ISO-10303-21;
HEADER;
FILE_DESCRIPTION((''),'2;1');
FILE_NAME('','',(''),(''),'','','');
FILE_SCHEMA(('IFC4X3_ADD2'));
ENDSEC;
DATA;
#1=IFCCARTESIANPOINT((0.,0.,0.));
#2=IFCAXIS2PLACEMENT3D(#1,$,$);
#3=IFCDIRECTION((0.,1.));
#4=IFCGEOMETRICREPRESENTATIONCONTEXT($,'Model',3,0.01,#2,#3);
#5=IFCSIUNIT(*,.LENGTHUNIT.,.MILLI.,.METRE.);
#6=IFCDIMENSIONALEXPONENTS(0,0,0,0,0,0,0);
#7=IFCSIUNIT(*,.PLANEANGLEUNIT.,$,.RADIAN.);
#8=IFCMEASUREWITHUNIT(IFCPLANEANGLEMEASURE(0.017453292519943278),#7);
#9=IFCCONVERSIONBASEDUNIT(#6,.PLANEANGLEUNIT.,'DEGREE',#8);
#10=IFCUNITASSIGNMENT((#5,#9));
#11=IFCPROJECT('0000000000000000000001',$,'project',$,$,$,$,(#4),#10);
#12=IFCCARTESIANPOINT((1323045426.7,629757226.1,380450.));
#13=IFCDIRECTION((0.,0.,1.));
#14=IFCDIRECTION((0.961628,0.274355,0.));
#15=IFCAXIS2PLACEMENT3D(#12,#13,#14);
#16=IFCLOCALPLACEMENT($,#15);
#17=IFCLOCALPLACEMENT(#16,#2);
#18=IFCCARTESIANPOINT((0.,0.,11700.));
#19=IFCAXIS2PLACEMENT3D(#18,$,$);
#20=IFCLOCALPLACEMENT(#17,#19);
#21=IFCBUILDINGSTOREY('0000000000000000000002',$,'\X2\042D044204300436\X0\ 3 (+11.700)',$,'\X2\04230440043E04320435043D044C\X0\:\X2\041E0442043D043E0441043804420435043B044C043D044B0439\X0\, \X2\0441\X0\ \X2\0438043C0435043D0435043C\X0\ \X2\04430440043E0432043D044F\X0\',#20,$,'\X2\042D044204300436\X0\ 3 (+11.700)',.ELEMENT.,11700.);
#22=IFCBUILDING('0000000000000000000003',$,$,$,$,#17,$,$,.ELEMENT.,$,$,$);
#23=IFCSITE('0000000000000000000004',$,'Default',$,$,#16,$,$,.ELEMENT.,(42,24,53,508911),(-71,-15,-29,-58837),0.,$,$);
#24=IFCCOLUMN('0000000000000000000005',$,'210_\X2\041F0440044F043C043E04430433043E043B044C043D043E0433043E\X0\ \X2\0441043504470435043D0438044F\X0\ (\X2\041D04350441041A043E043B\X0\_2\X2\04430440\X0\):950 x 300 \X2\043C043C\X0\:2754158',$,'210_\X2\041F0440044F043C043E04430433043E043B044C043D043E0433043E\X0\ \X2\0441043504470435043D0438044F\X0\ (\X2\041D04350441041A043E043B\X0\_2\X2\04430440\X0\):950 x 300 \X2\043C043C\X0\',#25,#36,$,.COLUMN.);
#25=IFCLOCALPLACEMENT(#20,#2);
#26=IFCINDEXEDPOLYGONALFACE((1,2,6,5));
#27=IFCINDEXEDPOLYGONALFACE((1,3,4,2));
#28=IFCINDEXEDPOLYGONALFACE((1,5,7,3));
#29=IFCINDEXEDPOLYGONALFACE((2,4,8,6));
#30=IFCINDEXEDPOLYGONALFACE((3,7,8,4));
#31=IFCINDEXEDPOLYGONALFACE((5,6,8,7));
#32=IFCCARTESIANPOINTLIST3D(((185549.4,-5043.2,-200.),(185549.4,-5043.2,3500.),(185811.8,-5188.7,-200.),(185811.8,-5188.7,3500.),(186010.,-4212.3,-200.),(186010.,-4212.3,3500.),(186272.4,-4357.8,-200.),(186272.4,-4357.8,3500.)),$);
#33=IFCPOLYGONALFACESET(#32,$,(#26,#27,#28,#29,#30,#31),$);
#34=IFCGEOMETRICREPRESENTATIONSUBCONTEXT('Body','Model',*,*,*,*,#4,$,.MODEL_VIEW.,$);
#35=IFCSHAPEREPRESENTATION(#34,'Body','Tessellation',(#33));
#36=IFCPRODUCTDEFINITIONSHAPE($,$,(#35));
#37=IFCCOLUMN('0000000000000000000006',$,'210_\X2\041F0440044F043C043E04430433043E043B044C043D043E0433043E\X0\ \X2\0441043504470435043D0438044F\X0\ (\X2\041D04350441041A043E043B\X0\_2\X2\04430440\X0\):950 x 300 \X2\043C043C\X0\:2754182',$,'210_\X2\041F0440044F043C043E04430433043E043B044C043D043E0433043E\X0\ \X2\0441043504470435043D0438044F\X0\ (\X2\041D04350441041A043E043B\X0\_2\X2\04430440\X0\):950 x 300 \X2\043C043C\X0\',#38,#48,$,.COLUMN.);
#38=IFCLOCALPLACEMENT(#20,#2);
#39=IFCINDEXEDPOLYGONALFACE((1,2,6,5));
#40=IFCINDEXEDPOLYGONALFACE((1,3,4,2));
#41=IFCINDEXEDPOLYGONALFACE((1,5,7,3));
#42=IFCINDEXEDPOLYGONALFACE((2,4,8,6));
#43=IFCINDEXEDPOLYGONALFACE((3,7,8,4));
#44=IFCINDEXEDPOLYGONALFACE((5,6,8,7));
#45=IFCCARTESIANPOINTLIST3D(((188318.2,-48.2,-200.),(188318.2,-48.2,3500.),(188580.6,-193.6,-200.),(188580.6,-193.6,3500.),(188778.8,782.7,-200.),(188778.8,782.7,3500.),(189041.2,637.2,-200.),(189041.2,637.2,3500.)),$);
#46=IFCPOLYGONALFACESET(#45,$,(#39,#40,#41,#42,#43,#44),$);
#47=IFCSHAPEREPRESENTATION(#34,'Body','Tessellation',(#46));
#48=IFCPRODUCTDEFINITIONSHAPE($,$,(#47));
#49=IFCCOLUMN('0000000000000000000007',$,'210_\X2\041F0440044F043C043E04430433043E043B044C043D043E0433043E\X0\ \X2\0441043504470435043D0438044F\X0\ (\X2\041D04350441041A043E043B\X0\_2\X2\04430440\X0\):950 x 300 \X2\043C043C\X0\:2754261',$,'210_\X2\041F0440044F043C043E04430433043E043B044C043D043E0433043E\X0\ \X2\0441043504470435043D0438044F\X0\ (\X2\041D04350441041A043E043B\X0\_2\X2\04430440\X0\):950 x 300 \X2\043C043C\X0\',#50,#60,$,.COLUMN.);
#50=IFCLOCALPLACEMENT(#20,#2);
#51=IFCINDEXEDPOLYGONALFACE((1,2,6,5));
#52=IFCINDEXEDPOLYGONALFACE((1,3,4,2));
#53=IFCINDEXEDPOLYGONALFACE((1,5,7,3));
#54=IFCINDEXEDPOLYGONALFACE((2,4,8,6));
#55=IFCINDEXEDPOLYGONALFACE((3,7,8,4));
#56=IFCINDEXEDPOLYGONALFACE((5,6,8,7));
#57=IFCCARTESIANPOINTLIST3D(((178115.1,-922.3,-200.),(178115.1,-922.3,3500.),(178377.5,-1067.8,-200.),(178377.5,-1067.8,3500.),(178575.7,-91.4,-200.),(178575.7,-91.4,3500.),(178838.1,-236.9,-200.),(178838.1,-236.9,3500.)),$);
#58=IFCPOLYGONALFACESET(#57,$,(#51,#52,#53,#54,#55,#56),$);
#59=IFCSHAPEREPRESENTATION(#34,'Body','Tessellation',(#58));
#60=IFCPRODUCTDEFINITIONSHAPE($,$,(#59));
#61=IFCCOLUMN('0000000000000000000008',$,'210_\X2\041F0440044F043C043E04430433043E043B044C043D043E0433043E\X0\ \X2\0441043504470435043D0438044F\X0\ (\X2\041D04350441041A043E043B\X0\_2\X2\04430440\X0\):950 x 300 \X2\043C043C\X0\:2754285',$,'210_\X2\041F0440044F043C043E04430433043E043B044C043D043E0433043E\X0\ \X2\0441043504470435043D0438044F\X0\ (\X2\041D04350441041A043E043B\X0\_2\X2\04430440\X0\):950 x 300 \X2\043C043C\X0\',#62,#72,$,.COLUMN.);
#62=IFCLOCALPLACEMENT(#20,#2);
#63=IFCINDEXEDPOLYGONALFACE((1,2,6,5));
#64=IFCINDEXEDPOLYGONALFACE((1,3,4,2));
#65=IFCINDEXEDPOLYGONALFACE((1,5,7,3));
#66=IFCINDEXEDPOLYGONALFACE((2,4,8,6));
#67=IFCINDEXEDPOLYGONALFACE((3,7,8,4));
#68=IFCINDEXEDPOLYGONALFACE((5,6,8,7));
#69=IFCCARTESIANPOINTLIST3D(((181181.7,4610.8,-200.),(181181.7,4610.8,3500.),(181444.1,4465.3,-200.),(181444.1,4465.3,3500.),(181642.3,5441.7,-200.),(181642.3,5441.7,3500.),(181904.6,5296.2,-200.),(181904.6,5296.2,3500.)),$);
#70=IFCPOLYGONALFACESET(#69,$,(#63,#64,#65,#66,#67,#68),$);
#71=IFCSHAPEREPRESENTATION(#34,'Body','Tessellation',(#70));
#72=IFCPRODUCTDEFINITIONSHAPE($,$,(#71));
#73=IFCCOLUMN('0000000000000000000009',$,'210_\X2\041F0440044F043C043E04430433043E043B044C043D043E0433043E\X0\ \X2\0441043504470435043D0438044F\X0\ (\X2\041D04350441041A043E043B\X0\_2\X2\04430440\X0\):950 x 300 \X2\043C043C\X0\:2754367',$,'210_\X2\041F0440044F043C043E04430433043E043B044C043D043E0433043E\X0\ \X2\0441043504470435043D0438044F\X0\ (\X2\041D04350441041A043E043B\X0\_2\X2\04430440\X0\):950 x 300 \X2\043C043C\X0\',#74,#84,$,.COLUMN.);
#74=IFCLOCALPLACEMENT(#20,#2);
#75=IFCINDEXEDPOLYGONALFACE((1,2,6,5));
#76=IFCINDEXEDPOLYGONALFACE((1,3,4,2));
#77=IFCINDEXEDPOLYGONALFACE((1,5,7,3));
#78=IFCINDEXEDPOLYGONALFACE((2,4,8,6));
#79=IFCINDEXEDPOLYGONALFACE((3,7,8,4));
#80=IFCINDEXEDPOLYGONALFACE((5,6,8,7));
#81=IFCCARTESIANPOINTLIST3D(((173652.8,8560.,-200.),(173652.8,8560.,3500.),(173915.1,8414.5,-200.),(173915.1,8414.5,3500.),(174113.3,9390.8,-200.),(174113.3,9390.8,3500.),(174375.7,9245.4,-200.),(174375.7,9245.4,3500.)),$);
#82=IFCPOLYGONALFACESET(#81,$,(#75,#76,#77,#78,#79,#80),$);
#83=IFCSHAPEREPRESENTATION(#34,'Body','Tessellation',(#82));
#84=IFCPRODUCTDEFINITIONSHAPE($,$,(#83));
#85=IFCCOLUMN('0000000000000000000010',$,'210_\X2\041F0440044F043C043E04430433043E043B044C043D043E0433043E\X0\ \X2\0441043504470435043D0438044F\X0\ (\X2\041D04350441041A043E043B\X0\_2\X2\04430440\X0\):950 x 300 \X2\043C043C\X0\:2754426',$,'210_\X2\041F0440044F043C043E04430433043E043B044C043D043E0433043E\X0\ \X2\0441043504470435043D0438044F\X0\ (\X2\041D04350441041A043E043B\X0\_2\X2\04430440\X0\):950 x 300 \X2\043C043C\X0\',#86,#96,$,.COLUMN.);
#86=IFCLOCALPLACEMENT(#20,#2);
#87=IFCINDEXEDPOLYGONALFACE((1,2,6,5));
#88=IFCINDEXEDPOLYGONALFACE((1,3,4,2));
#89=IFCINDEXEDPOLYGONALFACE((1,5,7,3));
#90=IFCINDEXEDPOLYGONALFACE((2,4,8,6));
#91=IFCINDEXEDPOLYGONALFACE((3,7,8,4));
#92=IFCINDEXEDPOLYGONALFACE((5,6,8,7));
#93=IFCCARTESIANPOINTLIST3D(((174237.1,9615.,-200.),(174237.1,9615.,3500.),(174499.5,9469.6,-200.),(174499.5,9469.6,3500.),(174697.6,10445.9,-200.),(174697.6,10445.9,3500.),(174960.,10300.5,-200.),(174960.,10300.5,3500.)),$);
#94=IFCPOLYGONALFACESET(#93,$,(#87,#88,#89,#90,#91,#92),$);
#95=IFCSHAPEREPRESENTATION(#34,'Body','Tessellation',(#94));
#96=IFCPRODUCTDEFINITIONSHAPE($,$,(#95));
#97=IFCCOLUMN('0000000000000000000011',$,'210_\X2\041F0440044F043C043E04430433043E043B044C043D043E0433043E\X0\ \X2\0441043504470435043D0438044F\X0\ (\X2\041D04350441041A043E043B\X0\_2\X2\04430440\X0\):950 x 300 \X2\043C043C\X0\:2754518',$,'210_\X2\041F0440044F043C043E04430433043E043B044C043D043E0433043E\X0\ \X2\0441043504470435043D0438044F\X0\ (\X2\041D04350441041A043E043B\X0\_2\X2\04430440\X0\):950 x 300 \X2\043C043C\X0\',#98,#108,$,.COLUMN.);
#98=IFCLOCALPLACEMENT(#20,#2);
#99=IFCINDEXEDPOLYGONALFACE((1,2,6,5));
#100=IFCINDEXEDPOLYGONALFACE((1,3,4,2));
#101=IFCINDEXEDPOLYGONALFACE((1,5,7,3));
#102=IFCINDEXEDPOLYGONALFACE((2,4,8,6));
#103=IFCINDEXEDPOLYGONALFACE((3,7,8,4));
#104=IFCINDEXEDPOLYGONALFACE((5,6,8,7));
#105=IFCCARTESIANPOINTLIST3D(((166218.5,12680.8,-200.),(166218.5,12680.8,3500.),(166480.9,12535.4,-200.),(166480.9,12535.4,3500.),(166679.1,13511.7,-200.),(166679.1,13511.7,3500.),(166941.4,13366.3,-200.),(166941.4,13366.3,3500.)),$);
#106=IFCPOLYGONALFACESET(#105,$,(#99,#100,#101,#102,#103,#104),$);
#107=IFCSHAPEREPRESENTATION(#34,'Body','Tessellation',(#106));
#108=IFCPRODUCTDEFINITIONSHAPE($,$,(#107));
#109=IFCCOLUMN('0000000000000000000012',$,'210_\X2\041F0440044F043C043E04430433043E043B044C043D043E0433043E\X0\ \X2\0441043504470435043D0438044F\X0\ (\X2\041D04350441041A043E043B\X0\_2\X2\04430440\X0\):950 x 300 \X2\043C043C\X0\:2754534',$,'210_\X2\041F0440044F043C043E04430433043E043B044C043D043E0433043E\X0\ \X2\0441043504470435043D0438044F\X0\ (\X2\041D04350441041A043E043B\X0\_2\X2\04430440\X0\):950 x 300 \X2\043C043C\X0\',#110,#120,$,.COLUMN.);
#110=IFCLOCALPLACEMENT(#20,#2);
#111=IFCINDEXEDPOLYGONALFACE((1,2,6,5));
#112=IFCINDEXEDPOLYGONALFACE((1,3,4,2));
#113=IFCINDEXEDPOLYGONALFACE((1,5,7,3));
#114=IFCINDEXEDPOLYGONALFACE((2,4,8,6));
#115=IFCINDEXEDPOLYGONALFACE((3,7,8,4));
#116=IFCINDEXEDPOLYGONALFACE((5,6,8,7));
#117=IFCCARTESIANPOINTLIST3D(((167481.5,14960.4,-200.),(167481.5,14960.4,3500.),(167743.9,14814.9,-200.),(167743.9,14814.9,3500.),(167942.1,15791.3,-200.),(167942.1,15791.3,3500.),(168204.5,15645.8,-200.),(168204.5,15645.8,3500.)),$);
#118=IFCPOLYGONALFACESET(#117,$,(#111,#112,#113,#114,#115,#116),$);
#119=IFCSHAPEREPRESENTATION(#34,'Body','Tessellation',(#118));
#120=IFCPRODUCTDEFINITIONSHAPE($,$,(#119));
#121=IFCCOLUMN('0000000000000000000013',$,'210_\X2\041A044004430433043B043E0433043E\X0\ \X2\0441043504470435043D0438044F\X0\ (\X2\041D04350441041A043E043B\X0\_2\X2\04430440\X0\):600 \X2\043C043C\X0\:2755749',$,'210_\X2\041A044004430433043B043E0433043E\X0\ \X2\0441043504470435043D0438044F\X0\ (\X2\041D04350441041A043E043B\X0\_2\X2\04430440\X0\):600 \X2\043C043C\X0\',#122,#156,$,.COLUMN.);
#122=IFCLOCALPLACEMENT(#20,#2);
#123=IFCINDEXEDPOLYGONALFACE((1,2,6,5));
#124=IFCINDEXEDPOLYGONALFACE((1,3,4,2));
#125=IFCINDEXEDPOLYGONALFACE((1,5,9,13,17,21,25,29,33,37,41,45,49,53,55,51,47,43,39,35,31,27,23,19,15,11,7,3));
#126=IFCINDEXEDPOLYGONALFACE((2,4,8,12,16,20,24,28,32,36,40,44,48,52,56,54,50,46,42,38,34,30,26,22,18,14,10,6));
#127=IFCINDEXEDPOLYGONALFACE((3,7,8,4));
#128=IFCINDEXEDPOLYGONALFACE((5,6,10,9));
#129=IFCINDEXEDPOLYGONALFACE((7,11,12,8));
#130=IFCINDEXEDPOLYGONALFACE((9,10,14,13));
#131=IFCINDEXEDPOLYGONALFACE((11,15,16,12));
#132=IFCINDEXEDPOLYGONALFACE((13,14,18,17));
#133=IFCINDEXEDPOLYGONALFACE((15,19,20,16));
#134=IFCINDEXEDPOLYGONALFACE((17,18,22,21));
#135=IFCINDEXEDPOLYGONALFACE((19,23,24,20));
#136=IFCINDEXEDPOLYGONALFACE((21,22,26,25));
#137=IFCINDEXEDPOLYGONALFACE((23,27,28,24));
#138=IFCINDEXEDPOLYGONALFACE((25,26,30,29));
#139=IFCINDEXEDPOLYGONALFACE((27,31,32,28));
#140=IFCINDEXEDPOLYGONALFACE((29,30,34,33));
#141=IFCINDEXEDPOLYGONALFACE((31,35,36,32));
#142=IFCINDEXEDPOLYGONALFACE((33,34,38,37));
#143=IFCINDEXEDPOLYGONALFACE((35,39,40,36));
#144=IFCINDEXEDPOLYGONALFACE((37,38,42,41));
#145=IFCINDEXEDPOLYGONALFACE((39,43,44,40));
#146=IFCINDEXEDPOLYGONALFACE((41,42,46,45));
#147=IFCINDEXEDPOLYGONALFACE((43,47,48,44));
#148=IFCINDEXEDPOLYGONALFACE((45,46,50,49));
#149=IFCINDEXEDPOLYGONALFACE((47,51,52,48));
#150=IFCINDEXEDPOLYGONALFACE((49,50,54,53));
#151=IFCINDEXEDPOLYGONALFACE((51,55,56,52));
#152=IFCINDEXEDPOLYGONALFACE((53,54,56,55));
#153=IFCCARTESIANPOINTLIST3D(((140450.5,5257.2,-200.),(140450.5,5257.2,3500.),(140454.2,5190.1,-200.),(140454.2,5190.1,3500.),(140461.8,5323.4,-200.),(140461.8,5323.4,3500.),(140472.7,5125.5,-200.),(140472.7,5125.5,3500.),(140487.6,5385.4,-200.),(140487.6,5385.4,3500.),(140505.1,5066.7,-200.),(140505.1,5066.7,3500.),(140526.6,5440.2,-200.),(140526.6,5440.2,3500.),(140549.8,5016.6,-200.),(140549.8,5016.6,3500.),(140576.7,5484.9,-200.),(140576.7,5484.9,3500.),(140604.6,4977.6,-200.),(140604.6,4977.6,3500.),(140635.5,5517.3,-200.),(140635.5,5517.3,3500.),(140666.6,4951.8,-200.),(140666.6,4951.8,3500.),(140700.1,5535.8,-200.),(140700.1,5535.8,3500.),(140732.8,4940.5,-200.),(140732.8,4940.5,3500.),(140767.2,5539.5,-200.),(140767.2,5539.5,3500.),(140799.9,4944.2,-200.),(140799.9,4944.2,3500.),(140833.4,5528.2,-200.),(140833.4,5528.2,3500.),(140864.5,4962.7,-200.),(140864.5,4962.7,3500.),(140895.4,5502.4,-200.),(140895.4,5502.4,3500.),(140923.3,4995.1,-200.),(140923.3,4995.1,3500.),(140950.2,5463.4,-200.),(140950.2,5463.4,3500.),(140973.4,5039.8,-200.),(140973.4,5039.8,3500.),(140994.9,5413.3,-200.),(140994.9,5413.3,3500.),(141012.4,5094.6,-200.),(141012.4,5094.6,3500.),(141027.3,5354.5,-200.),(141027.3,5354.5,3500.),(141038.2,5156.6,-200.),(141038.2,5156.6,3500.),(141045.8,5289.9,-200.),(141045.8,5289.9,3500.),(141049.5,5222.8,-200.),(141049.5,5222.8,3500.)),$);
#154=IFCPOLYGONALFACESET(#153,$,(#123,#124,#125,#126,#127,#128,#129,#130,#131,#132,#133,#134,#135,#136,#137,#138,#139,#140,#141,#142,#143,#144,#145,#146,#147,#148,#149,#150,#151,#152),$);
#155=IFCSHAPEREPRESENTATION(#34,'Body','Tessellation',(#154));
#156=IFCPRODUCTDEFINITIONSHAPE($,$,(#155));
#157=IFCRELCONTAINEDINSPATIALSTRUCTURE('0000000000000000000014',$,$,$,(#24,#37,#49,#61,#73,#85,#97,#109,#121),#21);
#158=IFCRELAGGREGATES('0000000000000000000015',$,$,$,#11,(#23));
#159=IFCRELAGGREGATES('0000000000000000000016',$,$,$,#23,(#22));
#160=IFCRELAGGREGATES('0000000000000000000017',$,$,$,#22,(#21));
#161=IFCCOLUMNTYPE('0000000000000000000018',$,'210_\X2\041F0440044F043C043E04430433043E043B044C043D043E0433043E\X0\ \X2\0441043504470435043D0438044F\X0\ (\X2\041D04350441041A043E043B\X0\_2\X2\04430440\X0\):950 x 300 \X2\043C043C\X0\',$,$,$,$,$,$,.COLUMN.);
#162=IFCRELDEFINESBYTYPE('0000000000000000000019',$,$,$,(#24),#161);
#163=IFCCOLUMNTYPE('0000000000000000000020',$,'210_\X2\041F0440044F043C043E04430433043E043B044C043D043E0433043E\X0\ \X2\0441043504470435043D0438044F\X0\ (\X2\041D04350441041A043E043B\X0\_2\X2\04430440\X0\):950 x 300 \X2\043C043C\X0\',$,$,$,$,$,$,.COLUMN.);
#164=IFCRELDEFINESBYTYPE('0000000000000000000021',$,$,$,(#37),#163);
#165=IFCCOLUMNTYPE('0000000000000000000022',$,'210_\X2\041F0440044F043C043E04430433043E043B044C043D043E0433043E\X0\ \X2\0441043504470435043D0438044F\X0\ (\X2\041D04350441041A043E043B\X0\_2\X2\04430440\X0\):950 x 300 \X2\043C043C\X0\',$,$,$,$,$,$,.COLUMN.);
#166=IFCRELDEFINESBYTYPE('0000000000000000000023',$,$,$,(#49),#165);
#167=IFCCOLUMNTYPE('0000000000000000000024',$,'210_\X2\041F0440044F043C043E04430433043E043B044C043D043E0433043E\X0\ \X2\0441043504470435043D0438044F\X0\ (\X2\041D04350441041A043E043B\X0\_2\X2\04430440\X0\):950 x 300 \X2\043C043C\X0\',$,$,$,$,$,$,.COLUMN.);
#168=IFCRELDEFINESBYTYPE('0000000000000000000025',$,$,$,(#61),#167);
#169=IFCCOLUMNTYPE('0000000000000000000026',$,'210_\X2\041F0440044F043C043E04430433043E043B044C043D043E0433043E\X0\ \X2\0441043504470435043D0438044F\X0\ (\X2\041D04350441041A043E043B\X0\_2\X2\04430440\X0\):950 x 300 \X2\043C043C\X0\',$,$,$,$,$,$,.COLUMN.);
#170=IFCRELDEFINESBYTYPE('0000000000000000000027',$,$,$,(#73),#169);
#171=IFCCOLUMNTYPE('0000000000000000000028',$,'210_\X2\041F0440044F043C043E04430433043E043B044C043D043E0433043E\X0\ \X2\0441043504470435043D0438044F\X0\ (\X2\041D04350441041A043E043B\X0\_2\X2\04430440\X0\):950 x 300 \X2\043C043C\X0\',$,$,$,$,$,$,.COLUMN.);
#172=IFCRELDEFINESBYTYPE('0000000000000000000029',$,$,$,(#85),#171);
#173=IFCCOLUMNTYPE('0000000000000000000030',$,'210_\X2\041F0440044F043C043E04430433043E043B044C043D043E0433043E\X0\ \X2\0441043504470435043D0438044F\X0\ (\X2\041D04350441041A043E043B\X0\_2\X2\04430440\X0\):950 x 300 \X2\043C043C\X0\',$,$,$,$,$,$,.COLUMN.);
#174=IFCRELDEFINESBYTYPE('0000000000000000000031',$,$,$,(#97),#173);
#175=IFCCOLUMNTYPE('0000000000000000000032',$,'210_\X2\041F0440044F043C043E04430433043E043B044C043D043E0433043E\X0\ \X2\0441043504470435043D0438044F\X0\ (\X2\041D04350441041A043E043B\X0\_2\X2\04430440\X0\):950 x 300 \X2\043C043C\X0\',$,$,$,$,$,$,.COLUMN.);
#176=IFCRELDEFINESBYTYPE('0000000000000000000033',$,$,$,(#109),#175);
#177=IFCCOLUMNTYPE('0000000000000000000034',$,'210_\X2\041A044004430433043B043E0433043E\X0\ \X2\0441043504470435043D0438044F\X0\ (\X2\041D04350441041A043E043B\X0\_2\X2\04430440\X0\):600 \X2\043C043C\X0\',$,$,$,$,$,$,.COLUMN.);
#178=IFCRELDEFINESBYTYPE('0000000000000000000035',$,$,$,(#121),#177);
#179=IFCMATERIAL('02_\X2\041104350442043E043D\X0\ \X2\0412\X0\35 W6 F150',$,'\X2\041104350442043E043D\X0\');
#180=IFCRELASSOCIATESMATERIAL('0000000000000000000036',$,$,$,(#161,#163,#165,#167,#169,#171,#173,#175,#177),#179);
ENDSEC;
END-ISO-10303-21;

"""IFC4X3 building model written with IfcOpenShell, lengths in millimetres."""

from ifc_helpers import new_model, entity, si_unit, converted_unit, direction, frame, frame_2d, origin, origin_2d_with_axis, place, context, subcontext, project, spatial, rectangle, circle, extrude, source, transform, mapped, material, material_profile, profile_set, type_object, type_shapes, element, save


model = new_model("IFC4X3")

# Units and contexts
model_context = context("Model", 3, precision=0.01, world=origin(), true_north=direction((0.0, 1.0)))
body_context = subcontext(model_context, "Body", "Model", "MODEL_VIEW")
ifc_project = project(units=[si_unit("LENGTHUNIT", "METRE", prefix="MILLI"), converted_unit("PLANEANGLEUNIT", "DEGREE", entity("IfcPlaneAngleMeasure", 0.017453292519943278), si_unit("PLANEANGLEUNIT", "RADIAN"), dimensions=[0, 0, 0, 0, 0, 0, 0])], contexts=[model_context])

# Site, building, storey
site_placement = place(None, frame((1323045426.7, 629757226.1, 380450.0), z_axis=(0.0, 0.0, 1.0), x_axis=(0.961628, 0.274355, 0.0)))
site = spatial("IfcSite", under=ifc_project, at=site_placement, Name="Default", CompositionType="ELEMENT", RefLatitude=(42, 24, 53, 508911), RefLongitude=(-71, -15, -29, -58837), RefElevation=0.0)
building_placement = place(site_placement, origin())
building = spatial("IfcBuilding", under=site, at=building_placement, CompositionType="ELEMENT")
storey_placement = place(building_placement, frame((0.0, 0.0, 11700.0)))
storey = spatial("IfcBuildingStorey", under=building, at=storey_placement, Name="Этаж 3 (+11.700)", ObjectType="Уровень:Относительный, с именем уровня", LongName="Этаж 3 (+11.700)", CompositionType="ELEMENT", Elevation=11700.0)

# Columns
ifc_material = material(Name="02_Бетон В35 W6 F150", Category="Бетон")
ifc_material_profile_1 = material_profile(ifc_material, rectangle(XDim=300.0, YDim=950.0, at=frame_2d((0.0, 0.0), x_axis=(1.0, 0.0))), Name="950 x 300 мм")
ifc_profile_set_1 = profile_set([ifc_material_profile_1], Name="950 x 300 мм")
column_type_1 = type_object("IfcColumnType", Name="210_Прямоугольного сечения (НесКол_2ур):950 x 300 мм", PredefinedType="COLUMN", material=ifc_profile_set_1)
shared_shape_1 = source(origin(), body_context, "Body", "SweptSolid", [
    extrude(rectangle(XDim=300.0, YDim=950.0, at=frame_2d((0.0, 0.0), x_axis=(1.0, 0.0))), frame((185910.9, -4700.5, 11500.0), z_axis=(0.0, 0.0, 1.0), x_axis=(-0.87462, 0.48481, 0.0)), (0.0, 0.0, 1.0), 3700.0),
])
type_shapes(column_type_1, [shared_shape_1])
column_1_placement = place(storey_placement, frame((0.0, 0.0, -11700.0)))
element("IfcColumn", 1, at=column_1_placement, inside=storey, type_object=column_type_1, Name="210_Прямоугольного сечения (НесКол_2ур):950 x 300 мм:2754158", ObjectType="210_Прямоугольного сечения (НесКол_2ур):950 x 300 мм", PredefinedType="COLUMN", context=body_context, shape_type="MappedRepresentation", body=[
    mapped(shared_shape_1, transform((0.0, 0.0, 0.0), scale=1.0)),
])
column_type_2 = type_object("IfcColumnType", Name="210_Прямоугольного сечения (НесКол_2ур):950 x 300 мм", PredefinedType="COLUMN", material=ifc_profile_set_1)
shared_shape_2 = source(origin(), body_context, "Body", "SweptSolid", [
    extrude(rectangle(XDim=300.0, YDim=950.0, at=origin_2d_with_axis()), frame((188679.7, 294.5, 11500.0), z_axis=(0.0, 0.0, 1.0), x_axis=(-0.87462, 0.48481, 0.0)), (0.0, 0.0, 1.0), 3700.0),
])
type_shapes(column_type_2, [shared_shape_2])
column_2_placement = place(storey_placement, frame((0.0, 0.0, -11700.0)))
element("IfcColumn", 2, at=column_2_placement, inside=storey, type_object=column_type_2, Name="210_Прямоугольного сечения (НесКол_2ур):950 x 300 мм:2754182", ObjectType="210_Прямоугольного сечения (НесКол_2ур):950 x 300 мм", PredefinedType="COLUMN", context=body_context, shape_type="MappedRepresentation", body=[
    mapped(shared_shape_2, transform((0.0, 0.0, 0.0), scale=1.0)),
])
column_type_3 = type_object("IfcColumnType", Name="210_Прямоугольного сечения (НесКол_2ур):950 x 300 мм", PredefinedType="COLUMN", material=ifc_profile_set_1)
shared_shape_3 = source(origin(), body_context, "Body", "SweptSolid", [
    extrude(rectangle(XDim=300.0, YDim=950.0, at=origin_2d_with_axis()), frame((178476.6, -579.6, 11500.0), z_axis=(0.0, 0.0, 1.0), x_axis=(-0.87462, 0.48481, 0.0)), (0.0, 0.0, 1.0), 3700.0),
])
type_shapes(column_type_3, [shared_shape_3])
column_3_placement = place(storey_placement, frame((0.0, 0.0, -11700.0)))
element("IfcColumn", 3, at=column_3_placement, inside=storey, type_object=column_type_3, Name="210_Прямоугольного сечения (НесКол_2ур):950 x 300 мм:2754261", ObjectType="210_Прямоугольного сечения (НесКол_2ур):950 x 300 мм", PredefinedType="COLUMN", context=body_context, shape_type="MappedRepresentation", body=[
    mapped(shared_shape_3, transform((0.0, 0.0, 0.0), scale=1.0)),
])
column_type_4 = type_object("IfcColumnType", Name="210_Прямоугольного сечения (НесКол_2ур):950 x 300 мм", PredefinedType="COLUMN", material=ifc_profile_set_1)
shared_shape_4 = source(origin(), body_context, "Body", "SweptSolid", [
    extrude(rectangle(XDim=300.0, YDim=950.0, at=frame_2d((0.0, 0.0), x_axis=(1.0, 0.0))), frame((181543.2, 4953.5, 11500.0), z_axis=(0.0, 0.0, 1.0), x_axis=(-0.87462, 0.48481, 0.0)), (0.0, 0.0, 1.0), 3700.0),
])
type_shapes(column_type_4, [shared_shape_4])
column_4_placement = place(storey_placement, frame((0.0, 0.0, -11700.0)))
element("IfcColumn", 4, at=column_4_placement, inside=storey, type_object=column_type_4, Name="210_Прямоугольного сечения (НесКол_2ур):950 x 300 мм:2754285", ObjectType="210_Прямоугольного сечения (НесКол_2ур):950 x 300 мм", PredefinedType="COLUMN", context=body_context, shape_type="MappedRepresentation", body=[
    mapped(shared_shape_4, transform((0.0, 0.0, 0.0), scale=1.0)),
])
column_type_5 = type_object("IfcColumnType", Name="210_Прямоугольного сечения (НесКол_2ур):950 x 300 мм", PredefinedType="COLUMN", material=ifc_profile_set_1)
shared_shape_5 = source(origin(), body_context, "Body", "SweptSolid", [
    extrude(rectangle(XDim=300.0, YDim=950.0, at=frame_2d((0.0, 0.0), x_axis=(1.0, 0.0))), frame((174014.2, 8902.7, 11500.0), z_axis=(0.0, 0.0, 1.0), x_axis=(-0.87462, 0.48481, 0.0)), (0.0, 0.0, 1.0), 3700.0),
])
type_shapes(column_type_5, [shared_shape_5])
column_5_placement = place(storey_placement, frame((0.0, 0.0, -11700.0)))
element("IfcColumn", 5, at=column_5_placement, inside=storey, type_object=column_type_5, Name="210_Прямоугольного сечения (НесКол_2ур):950 x 300 мм:2754367", ObjectType="210_Прямоугольного сечения (НесКол_2ур):950 x 300 мм", PredefinedType="COLUMN", context=body_context, shape_type="MappedRepresentation", body=[
    mapped(shared_shape_5, transform((0.0, 0.0, 0.0), scale=1.0)),
])
column_type_6 = type_object("IfcColumnType", Name="210_Прямоугольного сечения (НесКол_2ур):950 x 300 мм", PredefinedType="COLUMN", material=ifc_profile_set_1)
shared_shape_6 = source(origin(), body_context, "Body", "SweptSolid", [
    extrude(rectangle(XDim=300.0, YDim=950.0, at=frame_2d((0.0, 0.0), x_axis=(1.0, 0.0))), frame((174598.6, 9957.8, 11500.0), z_axis=(0.0, 0.0, 1.0), x_axis=(-0.87462, 0.48481, 0.0)), (0.0, 0.0, 1.0), 3700.0),
])
type_shapes(column_type_6, [shared_shape_6])
column_6_placement = place(storey_placement, frame((0.0, 0.0, -11700.0)))
element("IfcColumn", 6, at=column_6_placement, inside=storey, type_object=column_type_6, Name="210_Прямоугольного сечения (НесКол_2ур):950 x 300 мм:2754426", ObjectType="210_Прямоугольного сечения (НесКол_2ур):950 x 300 мм", PredefinedType="COLUMN", context=body_context, shape_type="MappedRepresentation", body=[
    mapped(shared_shape_6, transform((0.0, 0.0, 0.0), scale=1.0)),
])
column_type_7 = type_object("IfcColumnType", Name="210_Прямоугольного сечения (НесКол_2ур):950 x 300 мм", PredefinedType="COLUMN", material=ifc_profile_set_1)
shared_shape_7 = source(origin(), body_context, "Body", "SweptSolid", [
    extrude(rectangle(XDim=300.0, YDim=950.0, at=frame_2d((0.0, 0.0), x_axis=(1.0, 0.0))), frame((166580.0, 13023.6, 11500.0), z_axis=(0.0, 0.0, 1.0), x_axis=(-0.87462, 0.48481, 0.0)), (0.0, 0.0, 1.0), 3700.0),
])
type_shapes(column_type_7, [shared_shape_7])
column_7_placement = place(storey_placement, frame((0.0, 0.0, -11700.0)))
element("IfcColumn", 7, at=column_7_placement, inside=storey, type_object=column_type_7, Name="210_Прямоугольного сечения (НесКол_2ур):950 x 300 мм:2754518", ObjectType="210_Прямоугольного сечения (НесКол_2ур):950 x 300 мм", PredefinedType="COLUMN", context=body_context, shape_type="MappedRepresentation", body=[
    mapped(shared_shape_7, transform((0.0, 0.0, 0.0), scale=1.0)),
])
column_type_8 = type_object("IfcColumnType", Name="210_Прямоугольного сечения (НесКол_2ур):950 x 300 мм", PredefinedType="COLUMN", material=ifc_profile_set_1)
shared_shape_8 = source(origin(), body_context, "Body", "SweptSolid", [
    extrude(rectangle(XDim=300.0, YDim=950.0, at=frame_2d((0.0, 0.0), x_axis=(1.0, 0.0))), frame((167843.0, 15303.1, 11500.0), z_axis=(0.0, 0.0, 1.0), x_axis=(-0.87462, 0.48481, 0.0)), (0.0, 0.0, 1.0), 3700.0),
])
type_shapes(column_type_8, [shared_shape_8])
column_8_placement = place(storey_placement, frame((0.0, 0.0, -11700.0)))
element("IfcColumn", 8, at=column_8_placement, inside=storey, type_object=column_type_8, Name="210_Прямоугольного сечения (НесКол_2ур):950 x 300 мм:2754534", ObjectType="210_Прямоугольного сечения (НесКол_2ур):950 x 300 мм", PredefinedType="COLUMN", context=body_context, shape_type="MappedRepresentation", body=[
    mapped(shared_shape_8, transform((0.0, 0.0, 0.0), scale=1.0)),
])
ifc_material_profile_2 = material_profile(ifc_material, circle(Radius=300.0, at=origin_2d_with_axis()), Name="600 мм")
ifc_profile_set_2 = profile_set([ifc_material_profile_2], Name="600 мм")
column_type_9 = type_object("IfcColumnType", Name="210_Круглого сечения (НесКол_2ур):600 мм", PredefinedType="COLUMN", material=ifc_profile_set_2)
shared_shape_9 = source(origin(), body_context, "Body", "SweptSolid", [
    extrude(circle(Radius=300.0, at=origin_2d_with_axis()), frame((140750.0, 5240.0, 11500.0), z_axis=(0.0, 0.0, 1.0), x_axis=(0.87462, -0.48481, 0.0)), (0.0, 0.0, 1.0), 3700.0),
])
type_shapes(column_type_9, [shared_shape_9])
column_9_placement = place(storey_placement, frame((0.0, 0.0, -11700.0)))
element("IfcColumn", 9, at=column_9_placement, inside=storey, type_object=column_type_9, Name="210_Круглого сечения (НесКол_2ур):600 мм:2755749", ObjectType="210_Круглого сечения (НесКол_2ур):600 мм", PredefinedType="COLUMN", context=body_context, shape_type="MappedRepresentation", body=[
    mapped(shared_shape_9, transform((0.0, 0.0, 0.0), scale=1.0)),
])

save(model, "model.ifc")
